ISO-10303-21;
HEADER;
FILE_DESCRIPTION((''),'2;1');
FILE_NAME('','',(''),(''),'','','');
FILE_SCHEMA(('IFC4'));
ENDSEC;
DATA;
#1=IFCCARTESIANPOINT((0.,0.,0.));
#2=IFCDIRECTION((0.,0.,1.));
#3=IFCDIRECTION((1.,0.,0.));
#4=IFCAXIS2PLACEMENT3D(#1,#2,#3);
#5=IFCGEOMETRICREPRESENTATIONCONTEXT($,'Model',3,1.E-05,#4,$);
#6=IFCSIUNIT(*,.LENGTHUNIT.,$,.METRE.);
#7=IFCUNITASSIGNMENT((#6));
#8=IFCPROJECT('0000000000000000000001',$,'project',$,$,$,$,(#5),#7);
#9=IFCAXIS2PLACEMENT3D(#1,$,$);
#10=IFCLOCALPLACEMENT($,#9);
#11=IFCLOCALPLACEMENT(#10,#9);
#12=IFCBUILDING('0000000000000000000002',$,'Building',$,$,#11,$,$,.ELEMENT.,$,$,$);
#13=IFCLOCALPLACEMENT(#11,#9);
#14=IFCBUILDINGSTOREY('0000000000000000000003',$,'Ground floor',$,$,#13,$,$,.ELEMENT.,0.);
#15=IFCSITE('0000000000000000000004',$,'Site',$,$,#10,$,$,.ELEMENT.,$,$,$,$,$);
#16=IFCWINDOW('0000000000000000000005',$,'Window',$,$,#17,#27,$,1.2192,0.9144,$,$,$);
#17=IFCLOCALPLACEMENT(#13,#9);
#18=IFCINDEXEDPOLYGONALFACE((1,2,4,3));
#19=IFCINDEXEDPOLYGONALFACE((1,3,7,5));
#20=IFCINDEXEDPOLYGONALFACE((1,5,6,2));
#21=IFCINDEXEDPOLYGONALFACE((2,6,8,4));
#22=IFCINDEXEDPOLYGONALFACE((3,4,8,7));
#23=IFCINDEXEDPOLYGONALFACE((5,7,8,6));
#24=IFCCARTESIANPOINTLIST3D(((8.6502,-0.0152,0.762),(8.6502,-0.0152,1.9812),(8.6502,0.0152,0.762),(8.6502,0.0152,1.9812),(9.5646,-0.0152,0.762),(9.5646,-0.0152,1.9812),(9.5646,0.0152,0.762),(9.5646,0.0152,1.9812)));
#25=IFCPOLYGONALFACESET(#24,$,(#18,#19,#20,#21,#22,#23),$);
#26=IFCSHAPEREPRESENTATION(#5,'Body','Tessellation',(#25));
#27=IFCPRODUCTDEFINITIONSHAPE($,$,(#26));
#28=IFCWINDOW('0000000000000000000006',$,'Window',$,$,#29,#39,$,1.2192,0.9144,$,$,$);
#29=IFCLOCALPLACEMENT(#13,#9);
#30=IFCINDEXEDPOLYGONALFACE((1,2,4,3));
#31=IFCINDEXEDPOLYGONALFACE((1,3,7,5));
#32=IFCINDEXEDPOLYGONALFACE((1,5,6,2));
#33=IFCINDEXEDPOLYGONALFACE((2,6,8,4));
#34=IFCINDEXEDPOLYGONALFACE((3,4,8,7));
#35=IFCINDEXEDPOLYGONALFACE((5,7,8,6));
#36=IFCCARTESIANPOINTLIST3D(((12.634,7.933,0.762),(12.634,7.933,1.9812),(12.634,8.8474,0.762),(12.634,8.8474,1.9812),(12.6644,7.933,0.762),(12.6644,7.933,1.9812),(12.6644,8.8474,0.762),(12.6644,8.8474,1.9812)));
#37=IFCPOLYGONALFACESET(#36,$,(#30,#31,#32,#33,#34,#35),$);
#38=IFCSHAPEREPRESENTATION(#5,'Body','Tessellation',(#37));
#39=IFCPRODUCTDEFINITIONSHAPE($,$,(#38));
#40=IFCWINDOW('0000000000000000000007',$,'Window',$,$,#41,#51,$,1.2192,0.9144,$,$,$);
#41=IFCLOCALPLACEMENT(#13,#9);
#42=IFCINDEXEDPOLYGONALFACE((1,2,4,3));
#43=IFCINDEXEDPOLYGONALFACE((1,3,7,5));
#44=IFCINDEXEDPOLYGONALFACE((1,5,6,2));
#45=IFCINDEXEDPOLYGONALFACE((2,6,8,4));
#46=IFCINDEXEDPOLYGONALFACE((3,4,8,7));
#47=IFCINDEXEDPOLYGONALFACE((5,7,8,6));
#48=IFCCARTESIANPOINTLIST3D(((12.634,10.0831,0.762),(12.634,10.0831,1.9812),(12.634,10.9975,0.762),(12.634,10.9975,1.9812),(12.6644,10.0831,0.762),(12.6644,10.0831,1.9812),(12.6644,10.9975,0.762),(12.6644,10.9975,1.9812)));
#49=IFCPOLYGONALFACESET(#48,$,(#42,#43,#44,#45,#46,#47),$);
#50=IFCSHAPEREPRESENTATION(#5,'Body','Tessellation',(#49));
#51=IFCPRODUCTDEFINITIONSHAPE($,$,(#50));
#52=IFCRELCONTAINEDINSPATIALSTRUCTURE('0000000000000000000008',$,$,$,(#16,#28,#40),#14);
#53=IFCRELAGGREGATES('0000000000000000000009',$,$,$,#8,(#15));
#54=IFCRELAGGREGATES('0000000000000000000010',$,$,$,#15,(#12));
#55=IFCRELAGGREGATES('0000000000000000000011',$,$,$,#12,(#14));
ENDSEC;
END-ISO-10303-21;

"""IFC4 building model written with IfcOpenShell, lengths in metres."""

from ifc_helpers import new_model, si_unit, frame, origin, origin_with_axes, origin_2d, place, context, project, spatial, rectangle, extrude, element, save


model = new_model("IFC4")

# Units and contexts
model_context = context("Model", 3, precision=1e-05, world=origin_with_axes())
ifc_project = project(units=[si_unit("LENGTHUNIT", "METRE")], contexts=[model_context])

# Site, building, storey
site_placement = place(None, origin())
site = spatial("IfcSite", under=ifc_project, at=site_placement, Name="Site", CompositionType="ELEMENT")
building_placement = place(site_placement, origin())
building = spatial("IfcBuilding", under=site, at=building_placement, Name="Building", CompositionType="ELEMENT")
storey_placement = place(building_placement, origin())
storey = spatial("IfcBuildingStorey", under=building, at=storey_placement, Name="Ground floor", CompositionType="ELEMENT", Elevation=0.0)

# Windows
for number, where, x_axis, name in (
    (1, (9.1074, 0.0, 0.762), (1.0, 0.0, 0.0), "Window"),
    (2, (12.6492, 8.3902, 0.762), (0.0, 1.0, 0.0), "Window"),
    (3, (12.6492, 10.5403, 0.762), (0.0, 1.0, 0.0), "Window"),
):
    element("IfcWindow", number, at=place(storey_placement, frame(where, x_axis=x_axis)), inside=storey, Name=name, OverallHeight=1.2192, OverallWidth=0.9144, context=model_context, shape_type="SweptSolid", body=[
        extrude(rectangle(XDim=0.9144, YDim=0.0305, at=origin_2d()), origin(), (0.0, 0.0, 1.0), 1.2192),
    ])

save(model, "model.ifc")
